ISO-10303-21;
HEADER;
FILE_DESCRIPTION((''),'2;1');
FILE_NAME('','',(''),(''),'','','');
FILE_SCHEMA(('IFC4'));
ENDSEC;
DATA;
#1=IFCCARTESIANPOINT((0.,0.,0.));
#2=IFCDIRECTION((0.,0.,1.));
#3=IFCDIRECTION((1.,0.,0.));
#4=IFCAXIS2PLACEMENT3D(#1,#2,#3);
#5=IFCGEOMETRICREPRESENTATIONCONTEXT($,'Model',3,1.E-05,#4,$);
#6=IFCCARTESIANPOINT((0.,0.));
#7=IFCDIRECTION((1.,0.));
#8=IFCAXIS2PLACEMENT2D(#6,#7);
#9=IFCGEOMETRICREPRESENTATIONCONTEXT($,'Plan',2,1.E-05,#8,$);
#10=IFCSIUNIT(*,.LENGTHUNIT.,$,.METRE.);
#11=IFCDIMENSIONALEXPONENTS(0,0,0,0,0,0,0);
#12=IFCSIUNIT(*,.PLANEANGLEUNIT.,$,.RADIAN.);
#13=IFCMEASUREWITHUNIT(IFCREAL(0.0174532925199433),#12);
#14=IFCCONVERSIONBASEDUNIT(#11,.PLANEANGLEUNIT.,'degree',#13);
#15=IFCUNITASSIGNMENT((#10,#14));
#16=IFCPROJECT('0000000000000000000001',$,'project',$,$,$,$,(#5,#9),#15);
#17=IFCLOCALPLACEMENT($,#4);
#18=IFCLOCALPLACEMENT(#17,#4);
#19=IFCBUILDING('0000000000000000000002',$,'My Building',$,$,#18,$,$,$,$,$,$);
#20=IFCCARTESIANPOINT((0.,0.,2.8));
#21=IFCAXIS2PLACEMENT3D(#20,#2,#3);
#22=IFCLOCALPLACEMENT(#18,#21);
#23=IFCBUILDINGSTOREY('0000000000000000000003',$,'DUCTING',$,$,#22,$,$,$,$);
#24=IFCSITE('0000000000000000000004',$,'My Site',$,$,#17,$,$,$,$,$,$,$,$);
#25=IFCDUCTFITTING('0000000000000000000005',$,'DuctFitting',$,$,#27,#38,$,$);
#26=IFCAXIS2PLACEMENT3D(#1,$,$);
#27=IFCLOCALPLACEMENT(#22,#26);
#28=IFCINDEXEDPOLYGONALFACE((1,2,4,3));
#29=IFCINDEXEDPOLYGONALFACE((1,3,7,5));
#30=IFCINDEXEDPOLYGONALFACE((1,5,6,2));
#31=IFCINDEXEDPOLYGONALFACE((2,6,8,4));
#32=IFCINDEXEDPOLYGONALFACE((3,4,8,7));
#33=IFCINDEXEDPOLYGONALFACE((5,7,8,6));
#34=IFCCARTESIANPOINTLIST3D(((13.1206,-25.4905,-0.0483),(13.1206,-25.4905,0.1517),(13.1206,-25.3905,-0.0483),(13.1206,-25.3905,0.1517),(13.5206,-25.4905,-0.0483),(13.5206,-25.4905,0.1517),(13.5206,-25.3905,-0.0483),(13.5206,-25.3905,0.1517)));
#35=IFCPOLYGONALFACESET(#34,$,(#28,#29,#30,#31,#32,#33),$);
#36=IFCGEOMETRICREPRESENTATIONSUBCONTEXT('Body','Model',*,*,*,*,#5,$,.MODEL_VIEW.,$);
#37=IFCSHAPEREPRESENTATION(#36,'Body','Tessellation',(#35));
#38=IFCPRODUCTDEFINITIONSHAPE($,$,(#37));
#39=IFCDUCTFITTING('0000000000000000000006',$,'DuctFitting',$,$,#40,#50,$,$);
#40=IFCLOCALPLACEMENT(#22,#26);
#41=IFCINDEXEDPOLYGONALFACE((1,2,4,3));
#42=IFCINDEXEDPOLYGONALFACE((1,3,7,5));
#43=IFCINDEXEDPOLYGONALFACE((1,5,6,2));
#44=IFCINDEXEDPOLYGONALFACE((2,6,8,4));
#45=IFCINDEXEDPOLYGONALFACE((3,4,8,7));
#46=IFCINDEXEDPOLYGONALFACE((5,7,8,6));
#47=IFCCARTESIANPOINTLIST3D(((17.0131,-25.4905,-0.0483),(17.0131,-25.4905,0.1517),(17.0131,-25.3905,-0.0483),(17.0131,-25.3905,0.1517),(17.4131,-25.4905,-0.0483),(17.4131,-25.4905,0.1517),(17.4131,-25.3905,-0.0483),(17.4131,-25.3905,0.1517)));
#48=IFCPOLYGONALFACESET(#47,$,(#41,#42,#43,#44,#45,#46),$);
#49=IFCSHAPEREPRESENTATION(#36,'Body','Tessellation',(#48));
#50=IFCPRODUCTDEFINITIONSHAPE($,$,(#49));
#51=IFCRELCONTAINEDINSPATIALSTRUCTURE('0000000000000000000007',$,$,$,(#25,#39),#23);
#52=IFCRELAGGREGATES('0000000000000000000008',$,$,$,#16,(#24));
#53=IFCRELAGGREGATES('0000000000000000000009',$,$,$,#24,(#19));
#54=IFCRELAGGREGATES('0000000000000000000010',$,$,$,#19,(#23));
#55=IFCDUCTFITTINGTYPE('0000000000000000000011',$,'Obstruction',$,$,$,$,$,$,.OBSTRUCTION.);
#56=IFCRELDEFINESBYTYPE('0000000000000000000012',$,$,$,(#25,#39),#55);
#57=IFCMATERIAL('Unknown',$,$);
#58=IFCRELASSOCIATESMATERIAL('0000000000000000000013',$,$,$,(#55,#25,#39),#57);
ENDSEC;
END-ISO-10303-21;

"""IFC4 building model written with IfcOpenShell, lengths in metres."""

from ifc_helpers import new_model, entity, si_unit, converted_unit, frame, origin_with_axes, origin_2d_with_axis, place, context, subcontext, project, spatial, rectangle, extrude, material, material_profile, profile_set, profile_usage, type_object, element, save


model = new_model("IFC4")

# Units and contexts
model_context = context("Model", 3, precision=1e-05, world=origin_with_axes())
plan_context = context("Plan", 2, precision=1e-05, world=origin_2d_with_axis())
body_context = subcontext(model_context, "Body", "Model", "MODEL_VIEW")
ifc_project = project(units=[si_unit("LENGTHUNIT", "METRE"), converted_unit("PLANEANGLEUNIT", "degree", entity("IfcReal", 0.0174532925199433), si_unit("PLANEANGLEUNIT", "RADIAN"), dimensions=[0, 0, 0, 0, 0, 0, 0])], contexts=[model_context, plan_context])

# Site, building, storey
site_placement = place(None, origin_with_axes())
site = spatial("IfcSite", under=ifc_project, at=site_placement, Name="My Site")
building_placement = place(site_placement, origin_with_axes())
building = spatial("IfcBuilding", under=site, at=building_placement, Name="My Building")
storey_placement = place(building_placement, frame((0.0, 0.0, 2.8), z_axis=(0.0, 0.0, 1.0), x_axis=(1.0, 0.0, 0.0)))
storey = spatial("IfcBuildingStorey", under=building, at=storey_placement, Name="DUCTING")

# Shared definitions
ifc_material = material(Name="Unknown")

# Duct fittings
ifc_material_profile_1 = material_profile(ifc_material, rectangle(XDim=0.4, YDim=0.2))
ifc_profile_set_1 = profile_set([ifc_material_profile_1])
duct_fitting_type_1 = type_object("IfcDuctFittingType", Name="Obstruction", PredefinedType="OBSTRUCTION", material=ifc_profile_set_1)
ifc_profile_usage_1 = profile_usage(ifc_profile_set_1, cardinal=5)
duct_fitting_1_placement = place(storey_placement, frame((13.3206, -25.4905, 0.0517), z_axis=(0.0, 1.0, 0.0), x_axis=(-1.0, 0.0, 0.0)))
element("IfcDuctFitting", 1, at=duct_fitting_1_placement, inside=storey, type_object=duct_fitting_type_1, material=ifc_profile_usage_1, Name="DuctFitting", context=body_context, shape_type="SweptSolid", body=[
    extrude(rectangle(XDim=0.4, YDim=0.2), origin_with_axes(), (0.0, 0.0, 1.0), 0.1),
])
ifc_profile_usage_2 = profile_usage(ifc_profile_set_1, cardinal=5)
duct_fitting_2_placement = place(storey_placement, frame((17.2131, -25.4905, 0.0517), z_axis=(0.0, 1.0, 0.0), x_axis=(-1.0, 0.0, 0.0)))
element("IfcDuctFitting", 2, at=duct_fitting_2_placement, inside=storey, type_object=duct_fitting_type_1, material=ifc_profile_usage_2, Name="DuctFitting", context=body_context, shape_type="SweptSolid", body=[
    extrude(rectangle(XDim=0.4, YDim=0.2), origin_with_axes(), (0.0, 0.0, 1.0), 0.1),
])

save(model, "model.ifc")
